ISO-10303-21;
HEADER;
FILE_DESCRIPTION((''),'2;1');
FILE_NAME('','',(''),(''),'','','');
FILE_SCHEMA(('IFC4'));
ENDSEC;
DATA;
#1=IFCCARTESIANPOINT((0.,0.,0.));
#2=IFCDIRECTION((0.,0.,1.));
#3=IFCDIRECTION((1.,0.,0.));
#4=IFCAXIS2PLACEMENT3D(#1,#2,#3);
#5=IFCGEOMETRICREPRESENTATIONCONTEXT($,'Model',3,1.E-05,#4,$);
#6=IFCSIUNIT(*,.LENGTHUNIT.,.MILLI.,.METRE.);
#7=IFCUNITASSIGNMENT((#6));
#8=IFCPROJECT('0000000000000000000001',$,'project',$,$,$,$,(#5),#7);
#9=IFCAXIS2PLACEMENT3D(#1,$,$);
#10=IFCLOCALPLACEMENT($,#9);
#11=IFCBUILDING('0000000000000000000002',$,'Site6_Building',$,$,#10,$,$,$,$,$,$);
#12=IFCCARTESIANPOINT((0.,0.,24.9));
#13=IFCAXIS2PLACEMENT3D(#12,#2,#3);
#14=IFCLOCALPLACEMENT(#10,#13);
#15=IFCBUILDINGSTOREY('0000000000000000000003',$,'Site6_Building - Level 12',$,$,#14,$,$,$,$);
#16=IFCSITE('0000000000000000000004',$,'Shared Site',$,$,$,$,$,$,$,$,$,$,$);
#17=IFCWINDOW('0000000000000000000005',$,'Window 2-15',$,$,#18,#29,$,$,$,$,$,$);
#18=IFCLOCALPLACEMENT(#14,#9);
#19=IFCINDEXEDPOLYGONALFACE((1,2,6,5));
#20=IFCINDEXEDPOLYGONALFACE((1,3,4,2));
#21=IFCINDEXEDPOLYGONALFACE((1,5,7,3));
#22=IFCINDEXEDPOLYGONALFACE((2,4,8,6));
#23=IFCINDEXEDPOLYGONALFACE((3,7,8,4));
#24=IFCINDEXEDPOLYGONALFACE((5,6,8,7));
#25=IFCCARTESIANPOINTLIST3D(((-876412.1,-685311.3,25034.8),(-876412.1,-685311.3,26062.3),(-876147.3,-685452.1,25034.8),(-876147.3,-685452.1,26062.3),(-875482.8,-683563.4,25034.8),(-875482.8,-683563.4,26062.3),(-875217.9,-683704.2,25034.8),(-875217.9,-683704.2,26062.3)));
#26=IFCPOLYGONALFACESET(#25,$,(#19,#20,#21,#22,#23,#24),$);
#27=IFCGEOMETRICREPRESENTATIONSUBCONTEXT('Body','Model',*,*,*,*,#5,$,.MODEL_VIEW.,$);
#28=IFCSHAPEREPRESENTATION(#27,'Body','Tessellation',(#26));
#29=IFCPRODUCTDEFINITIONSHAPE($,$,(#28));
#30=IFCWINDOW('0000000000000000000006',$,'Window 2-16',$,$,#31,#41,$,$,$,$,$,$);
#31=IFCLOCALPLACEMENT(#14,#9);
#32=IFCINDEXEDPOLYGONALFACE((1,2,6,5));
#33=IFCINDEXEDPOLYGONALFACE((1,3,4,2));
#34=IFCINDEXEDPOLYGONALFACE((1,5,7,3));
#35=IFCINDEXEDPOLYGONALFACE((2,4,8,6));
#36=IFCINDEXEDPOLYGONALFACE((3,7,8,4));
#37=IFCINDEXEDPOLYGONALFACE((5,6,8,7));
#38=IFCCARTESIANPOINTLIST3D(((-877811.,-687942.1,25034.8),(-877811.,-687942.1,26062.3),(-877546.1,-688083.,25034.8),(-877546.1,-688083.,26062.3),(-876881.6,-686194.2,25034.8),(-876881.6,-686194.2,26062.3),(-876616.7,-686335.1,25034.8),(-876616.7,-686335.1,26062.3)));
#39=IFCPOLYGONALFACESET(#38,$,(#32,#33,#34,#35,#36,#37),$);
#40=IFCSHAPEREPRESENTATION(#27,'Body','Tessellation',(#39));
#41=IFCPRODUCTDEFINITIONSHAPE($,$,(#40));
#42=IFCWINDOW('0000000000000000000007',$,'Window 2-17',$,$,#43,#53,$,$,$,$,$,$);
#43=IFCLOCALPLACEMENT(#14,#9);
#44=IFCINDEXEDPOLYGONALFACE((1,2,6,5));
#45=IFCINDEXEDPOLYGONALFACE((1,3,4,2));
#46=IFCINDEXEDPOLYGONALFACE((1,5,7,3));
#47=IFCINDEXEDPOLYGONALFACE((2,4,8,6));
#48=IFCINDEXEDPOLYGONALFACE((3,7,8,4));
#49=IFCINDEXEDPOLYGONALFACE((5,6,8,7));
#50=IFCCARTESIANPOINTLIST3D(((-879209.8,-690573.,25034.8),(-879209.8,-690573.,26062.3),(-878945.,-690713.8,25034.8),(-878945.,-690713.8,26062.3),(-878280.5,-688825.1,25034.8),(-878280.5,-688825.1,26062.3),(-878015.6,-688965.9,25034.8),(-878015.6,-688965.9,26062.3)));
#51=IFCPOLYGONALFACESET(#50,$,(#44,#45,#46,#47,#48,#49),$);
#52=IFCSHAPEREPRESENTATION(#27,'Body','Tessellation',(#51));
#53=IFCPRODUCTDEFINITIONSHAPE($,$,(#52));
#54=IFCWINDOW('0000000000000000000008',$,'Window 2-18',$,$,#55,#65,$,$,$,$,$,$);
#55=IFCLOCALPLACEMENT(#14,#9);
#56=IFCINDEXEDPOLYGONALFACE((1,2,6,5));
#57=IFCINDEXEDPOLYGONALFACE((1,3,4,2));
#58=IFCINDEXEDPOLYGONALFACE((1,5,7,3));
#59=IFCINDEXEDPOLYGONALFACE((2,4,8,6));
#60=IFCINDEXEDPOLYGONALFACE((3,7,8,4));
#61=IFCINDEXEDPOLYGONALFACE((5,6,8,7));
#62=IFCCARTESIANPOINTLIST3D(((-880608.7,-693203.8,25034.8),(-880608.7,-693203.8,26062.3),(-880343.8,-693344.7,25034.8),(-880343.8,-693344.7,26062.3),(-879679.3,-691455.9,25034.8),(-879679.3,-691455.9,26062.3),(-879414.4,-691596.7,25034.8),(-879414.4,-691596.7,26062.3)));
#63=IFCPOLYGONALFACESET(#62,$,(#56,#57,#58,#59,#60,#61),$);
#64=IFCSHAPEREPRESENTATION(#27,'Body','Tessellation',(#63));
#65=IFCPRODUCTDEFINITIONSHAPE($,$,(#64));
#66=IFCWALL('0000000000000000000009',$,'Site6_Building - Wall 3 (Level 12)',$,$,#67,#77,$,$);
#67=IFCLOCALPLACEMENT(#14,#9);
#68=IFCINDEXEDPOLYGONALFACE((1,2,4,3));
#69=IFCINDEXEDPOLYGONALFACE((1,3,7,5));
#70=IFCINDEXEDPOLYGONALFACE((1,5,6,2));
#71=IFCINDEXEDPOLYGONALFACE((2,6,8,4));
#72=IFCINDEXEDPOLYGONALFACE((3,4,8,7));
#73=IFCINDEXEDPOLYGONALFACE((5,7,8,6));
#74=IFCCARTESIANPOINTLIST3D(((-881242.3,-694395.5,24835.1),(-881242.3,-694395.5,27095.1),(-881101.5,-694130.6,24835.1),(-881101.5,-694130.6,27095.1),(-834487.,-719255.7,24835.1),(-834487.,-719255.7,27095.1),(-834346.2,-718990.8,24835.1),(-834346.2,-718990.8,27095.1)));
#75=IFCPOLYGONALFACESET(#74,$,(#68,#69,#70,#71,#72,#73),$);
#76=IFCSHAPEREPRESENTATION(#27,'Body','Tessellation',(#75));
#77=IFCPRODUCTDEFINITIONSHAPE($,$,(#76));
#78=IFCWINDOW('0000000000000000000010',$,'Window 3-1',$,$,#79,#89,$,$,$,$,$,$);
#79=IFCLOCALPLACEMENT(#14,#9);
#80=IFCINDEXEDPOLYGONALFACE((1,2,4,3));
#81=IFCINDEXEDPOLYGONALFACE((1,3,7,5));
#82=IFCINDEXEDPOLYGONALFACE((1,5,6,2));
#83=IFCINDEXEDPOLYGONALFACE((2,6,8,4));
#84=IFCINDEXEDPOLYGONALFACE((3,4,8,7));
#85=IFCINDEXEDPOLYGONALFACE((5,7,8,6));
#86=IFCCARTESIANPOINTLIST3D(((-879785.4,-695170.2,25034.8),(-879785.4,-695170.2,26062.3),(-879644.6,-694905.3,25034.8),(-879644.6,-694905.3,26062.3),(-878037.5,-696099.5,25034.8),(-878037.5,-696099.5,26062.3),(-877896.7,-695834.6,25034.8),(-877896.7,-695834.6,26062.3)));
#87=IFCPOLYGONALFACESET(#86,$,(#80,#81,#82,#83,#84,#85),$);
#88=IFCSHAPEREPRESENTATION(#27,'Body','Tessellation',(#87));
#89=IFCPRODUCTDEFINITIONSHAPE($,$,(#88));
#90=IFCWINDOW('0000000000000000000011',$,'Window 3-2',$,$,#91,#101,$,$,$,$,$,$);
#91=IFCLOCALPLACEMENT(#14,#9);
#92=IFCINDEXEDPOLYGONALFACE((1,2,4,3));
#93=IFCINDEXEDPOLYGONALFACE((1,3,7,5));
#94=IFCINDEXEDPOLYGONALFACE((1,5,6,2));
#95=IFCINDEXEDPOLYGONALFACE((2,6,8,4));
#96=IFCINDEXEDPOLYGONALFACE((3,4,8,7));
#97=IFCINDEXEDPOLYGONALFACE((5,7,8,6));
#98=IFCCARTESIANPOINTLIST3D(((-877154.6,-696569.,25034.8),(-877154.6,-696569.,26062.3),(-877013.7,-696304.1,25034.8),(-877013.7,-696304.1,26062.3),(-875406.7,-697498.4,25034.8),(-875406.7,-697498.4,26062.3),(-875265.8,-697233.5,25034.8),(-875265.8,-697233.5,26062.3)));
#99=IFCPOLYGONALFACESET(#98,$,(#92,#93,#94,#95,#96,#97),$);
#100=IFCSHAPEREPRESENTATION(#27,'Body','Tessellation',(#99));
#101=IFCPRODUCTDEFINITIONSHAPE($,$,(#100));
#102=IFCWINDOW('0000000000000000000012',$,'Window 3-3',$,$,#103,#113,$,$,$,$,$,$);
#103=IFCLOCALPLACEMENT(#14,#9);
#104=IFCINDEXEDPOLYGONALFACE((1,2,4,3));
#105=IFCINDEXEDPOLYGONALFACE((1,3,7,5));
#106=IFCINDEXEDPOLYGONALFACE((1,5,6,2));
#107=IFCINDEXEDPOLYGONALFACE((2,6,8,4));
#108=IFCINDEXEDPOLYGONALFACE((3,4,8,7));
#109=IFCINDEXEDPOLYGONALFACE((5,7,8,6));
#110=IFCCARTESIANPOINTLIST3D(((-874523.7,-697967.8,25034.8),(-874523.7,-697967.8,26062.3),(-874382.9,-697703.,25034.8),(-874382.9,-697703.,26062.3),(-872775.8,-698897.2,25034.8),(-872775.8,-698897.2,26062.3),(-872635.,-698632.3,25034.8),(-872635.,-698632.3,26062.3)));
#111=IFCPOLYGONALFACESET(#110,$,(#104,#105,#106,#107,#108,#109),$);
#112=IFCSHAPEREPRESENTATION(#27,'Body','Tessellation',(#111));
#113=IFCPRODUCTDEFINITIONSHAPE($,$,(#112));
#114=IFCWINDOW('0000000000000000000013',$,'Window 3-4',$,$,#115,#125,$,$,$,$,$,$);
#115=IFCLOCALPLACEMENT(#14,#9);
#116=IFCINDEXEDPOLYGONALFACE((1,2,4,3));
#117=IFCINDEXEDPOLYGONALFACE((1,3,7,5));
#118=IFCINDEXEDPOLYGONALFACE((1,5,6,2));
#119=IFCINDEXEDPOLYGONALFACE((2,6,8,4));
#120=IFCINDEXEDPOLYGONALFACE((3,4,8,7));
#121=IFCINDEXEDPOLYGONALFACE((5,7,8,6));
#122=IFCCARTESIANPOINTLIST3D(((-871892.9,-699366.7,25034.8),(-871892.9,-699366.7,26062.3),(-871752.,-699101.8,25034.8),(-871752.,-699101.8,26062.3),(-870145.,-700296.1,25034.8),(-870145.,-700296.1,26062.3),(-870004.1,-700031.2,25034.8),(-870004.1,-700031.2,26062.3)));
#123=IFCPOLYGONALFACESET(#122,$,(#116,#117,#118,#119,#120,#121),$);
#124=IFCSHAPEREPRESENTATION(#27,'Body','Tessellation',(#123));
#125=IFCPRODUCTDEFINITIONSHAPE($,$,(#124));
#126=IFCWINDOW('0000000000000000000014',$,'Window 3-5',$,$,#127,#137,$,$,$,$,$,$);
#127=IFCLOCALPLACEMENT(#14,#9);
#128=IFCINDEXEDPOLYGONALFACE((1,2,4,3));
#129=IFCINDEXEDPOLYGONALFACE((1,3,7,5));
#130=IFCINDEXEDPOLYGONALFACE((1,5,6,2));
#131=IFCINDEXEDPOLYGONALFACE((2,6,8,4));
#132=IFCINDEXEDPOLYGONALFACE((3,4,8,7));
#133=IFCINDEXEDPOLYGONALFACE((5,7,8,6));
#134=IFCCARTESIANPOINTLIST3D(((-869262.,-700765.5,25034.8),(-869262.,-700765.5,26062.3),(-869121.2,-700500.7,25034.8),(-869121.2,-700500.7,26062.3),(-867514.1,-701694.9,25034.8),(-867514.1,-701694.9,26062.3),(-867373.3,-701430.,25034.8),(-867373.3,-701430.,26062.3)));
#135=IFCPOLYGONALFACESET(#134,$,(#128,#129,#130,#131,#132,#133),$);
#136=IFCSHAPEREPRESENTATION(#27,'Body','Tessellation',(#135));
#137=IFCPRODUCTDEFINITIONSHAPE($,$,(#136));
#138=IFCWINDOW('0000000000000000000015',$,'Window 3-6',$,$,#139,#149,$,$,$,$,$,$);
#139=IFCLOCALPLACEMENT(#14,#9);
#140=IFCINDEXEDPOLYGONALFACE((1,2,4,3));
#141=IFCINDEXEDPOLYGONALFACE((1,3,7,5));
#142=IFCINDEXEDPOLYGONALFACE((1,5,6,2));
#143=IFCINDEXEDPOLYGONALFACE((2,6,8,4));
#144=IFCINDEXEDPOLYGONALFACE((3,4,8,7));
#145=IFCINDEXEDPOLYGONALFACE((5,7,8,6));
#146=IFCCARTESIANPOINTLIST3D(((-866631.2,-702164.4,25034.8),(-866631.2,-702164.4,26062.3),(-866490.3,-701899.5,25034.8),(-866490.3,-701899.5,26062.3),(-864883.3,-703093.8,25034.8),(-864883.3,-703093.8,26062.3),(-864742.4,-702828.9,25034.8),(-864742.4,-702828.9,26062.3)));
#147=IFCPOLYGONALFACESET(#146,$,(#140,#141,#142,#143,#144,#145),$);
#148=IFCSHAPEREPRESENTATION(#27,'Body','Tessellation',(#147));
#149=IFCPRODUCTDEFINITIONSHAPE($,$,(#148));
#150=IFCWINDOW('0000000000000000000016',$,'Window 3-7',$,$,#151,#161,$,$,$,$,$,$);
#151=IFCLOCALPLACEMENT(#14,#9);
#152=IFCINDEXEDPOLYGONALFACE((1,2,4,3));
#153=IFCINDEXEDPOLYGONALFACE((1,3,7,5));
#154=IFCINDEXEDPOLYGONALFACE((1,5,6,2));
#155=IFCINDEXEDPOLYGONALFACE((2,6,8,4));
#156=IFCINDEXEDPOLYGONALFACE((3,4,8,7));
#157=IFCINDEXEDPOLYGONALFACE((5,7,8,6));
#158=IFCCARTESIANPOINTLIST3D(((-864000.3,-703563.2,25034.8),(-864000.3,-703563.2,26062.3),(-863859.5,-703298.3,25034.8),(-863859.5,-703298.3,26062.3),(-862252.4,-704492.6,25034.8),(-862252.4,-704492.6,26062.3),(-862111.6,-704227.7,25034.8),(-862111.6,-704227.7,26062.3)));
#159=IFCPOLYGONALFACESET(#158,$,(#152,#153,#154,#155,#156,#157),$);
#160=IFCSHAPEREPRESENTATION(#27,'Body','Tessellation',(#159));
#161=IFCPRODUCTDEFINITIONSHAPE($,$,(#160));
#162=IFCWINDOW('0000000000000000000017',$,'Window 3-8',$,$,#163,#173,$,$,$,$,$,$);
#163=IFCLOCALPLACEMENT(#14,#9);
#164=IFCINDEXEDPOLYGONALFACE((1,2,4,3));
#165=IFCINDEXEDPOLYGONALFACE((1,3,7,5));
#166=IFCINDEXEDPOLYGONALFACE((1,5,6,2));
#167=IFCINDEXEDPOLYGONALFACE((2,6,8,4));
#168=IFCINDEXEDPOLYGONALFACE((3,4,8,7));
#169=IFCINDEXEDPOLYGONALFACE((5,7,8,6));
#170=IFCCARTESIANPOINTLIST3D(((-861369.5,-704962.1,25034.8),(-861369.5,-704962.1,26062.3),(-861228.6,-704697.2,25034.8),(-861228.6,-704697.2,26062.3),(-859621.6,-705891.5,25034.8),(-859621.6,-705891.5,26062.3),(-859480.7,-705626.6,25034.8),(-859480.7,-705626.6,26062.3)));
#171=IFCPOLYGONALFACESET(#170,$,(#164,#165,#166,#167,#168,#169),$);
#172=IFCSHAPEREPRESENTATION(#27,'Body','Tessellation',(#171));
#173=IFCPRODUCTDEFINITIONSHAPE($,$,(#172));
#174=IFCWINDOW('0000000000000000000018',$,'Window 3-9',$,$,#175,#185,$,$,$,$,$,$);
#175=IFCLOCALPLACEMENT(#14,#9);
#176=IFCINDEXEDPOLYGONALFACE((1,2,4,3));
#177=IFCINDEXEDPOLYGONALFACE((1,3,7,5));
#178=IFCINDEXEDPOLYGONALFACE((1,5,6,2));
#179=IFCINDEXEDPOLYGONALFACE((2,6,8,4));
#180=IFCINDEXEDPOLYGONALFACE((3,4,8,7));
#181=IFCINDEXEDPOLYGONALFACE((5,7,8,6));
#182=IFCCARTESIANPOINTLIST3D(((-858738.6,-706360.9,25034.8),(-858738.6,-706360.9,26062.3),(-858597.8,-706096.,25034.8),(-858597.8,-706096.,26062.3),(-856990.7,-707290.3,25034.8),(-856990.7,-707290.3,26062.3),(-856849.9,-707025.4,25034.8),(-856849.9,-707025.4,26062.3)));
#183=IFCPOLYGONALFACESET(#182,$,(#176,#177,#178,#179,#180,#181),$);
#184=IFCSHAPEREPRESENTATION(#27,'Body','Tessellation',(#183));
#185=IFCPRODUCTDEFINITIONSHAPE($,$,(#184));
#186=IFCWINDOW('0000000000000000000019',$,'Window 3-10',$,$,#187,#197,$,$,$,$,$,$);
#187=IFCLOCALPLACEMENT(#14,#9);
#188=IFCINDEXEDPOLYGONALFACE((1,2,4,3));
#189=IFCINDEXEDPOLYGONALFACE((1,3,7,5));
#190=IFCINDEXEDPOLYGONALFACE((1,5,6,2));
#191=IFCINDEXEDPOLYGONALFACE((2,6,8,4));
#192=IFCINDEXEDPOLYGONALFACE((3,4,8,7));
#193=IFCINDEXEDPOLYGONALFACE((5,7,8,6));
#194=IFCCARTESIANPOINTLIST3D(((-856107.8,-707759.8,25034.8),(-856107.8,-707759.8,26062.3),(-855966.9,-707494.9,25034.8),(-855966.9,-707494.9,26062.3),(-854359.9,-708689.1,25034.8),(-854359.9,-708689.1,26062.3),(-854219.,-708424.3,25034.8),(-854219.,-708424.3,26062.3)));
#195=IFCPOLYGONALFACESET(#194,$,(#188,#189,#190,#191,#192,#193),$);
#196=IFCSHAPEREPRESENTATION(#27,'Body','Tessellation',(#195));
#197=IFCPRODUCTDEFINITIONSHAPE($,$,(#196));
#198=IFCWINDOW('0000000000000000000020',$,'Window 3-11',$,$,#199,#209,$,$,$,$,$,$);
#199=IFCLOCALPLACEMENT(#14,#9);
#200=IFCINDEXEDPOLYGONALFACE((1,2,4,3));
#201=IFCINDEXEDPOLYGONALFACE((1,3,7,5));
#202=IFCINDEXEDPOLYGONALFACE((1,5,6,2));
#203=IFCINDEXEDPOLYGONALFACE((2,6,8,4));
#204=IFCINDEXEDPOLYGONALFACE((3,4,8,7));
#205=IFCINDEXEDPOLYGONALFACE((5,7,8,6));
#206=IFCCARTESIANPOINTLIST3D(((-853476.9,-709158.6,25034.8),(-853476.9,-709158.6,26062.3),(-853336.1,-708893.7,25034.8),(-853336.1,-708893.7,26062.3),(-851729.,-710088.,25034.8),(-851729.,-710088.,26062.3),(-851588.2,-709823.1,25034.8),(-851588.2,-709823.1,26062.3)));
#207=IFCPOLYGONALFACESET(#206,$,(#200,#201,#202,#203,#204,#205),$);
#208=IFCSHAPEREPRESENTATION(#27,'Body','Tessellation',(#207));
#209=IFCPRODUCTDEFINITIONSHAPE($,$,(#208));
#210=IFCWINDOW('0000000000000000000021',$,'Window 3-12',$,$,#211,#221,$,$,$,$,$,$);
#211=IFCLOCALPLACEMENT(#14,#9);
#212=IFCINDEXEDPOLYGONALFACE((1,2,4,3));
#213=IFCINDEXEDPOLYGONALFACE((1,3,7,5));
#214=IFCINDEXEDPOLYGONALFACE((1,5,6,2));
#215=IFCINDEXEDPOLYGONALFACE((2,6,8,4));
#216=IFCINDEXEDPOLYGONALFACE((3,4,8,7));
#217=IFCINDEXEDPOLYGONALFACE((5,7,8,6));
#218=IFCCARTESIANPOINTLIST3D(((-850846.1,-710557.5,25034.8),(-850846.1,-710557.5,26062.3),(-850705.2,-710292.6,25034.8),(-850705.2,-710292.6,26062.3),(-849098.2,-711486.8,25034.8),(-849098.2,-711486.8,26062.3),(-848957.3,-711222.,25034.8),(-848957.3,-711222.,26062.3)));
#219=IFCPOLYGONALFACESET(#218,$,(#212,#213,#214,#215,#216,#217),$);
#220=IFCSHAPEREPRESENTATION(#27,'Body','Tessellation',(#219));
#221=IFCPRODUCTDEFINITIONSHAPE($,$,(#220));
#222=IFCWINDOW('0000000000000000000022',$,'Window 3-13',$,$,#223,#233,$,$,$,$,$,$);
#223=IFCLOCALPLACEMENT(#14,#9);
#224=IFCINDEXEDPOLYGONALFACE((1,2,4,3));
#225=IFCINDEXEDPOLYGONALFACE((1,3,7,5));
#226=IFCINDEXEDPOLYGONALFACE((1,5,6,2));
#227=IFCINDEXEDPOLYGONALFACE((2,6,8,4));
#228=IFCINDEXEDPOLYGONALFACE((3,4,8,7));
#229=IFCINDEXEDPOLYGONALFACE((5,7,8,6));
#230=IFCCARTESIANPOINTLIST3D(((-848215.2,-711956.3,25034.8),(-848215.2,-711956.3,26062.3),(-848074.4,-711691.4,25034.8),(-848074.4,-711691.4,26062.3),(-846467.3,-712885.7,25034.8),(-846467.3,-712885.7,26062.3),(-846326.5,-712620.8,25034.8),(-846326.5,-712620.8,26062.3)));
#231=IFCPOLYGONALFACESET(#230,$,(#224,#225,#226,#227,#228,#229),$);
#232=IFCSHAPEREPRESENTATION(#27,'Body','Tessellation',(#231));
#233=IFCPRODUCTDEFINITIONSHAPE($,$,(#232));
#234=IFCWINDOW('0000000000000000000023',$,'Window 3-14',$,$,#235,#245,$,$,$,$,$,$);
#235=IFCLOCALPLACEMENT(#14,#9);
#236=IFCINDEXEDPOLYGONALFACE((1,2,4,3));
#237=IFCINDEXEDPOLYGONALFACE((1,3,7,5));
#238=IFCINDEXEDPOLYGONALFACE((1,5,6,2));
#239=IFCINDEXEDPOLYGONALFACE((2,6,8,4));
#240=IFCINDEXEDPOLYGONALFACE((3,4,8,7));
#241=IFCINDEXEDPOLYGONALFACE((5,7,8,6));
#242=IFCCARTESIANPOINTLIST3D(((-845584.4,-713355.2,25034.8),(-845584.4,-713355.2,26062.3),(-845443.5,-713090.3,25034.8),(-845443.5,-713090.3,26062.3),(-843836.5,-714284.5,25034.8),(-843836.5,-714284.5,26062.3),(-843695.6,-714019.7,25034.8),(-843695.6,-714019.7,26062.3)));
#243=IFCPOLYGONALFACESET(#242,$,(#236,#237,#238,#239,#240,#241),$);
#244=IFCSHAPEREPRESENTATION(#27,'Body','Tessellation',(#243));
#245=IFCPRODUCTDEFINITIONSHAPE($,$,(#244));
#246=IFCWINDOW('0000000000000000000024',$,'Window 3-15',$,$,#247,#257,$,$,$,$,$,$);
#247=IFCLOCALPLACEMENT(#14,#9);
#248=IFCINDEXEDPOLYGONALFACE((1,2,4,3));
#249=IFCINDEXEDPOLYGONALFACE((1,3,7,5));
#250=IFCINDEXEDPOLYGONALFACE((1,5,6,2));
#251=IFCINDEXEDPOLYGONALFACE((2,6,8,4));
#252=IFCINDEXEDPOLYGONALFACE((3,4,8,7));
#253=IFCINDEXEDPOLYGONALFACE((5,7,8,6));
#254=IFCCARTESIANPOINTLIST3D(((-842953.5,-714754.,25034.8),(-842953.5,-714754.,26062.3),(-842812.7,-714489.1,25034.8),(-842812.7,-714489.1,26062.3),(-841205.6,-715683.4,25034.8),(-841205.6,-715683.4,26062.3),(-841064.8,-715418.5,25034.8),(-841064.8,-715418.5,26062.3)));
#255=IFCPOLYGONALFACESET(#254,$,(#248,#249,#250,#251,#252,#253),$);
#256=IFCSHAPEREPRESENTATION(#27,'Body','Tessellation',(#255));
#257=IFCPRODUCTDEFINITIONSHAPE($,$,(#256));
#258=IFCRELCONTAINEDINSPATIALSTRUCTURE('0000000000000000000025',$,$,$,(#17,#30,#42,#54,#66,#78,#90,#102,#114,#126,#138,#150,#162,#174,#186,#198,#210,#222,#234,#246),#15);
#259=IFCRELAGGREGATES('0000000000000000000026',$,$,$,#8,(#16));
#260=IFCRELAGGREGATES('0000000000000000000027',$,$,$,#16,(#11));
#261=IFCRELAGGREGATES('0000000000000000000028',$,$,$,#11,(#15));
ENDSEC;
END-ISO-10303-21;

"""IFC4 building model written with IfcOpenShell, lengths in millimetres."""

from ifc_helpers import new_model, si_unit, frame, origin, origin_with_axes, place, context, subcontext, project, spatial, indexed_curve, outline, extrude, element, save


model = new_model("IFC4")

# Units and contexts
model_context = context("Model", 3, precision=1e-05, world=origin_with_axes())
body_context = subcontext(model_context, "Body", "Model", "MODEL_VIEW")
ifc_project = project(units=[si_unit("LENGTHUNIT", "METRE", prefix="MILLI")], contexts=[model_context])

# Site, building, storey
site = spatial("IfcSite", under=ifc_project, Name="Shared Site")
building_placement = place(None, origin())
building = spatial("IfcBuilding", under=site, at=building_placement, Name="Site6_Building")
storey_placement = place(building_placement, frame((0.0, 0.0, 24.9), z_axis=(0.0, 0.0, 1.0), x_axis=(1.0, 0.0, 0.0)))
storey = spatial("IfcBuildingStorey", under=building, at=storey_placement, Name="Site6_Building - Level 12")

# Windows
for number, where, z_axis, x_axis, name in (
    (1, (-875482.8, -683563.4, 25034.8), (0.0, 0.0, 1.0), (-0.469472, -0.882948, 0.0), "Window 2-15"),
    (2, (-876881.6, -686194.2, 25034.8), (0.0, 0.0, 1.0), (-0.469472, -0.882948, 0.0), "Window 2-16"),
    (3, (-878280.5, -688825.1, 25034.8), (0.0, 0.0, 1.0), (-0.469472, -0.882948, 0.0), "Window 2-17"),
    (4, (-879679.3, -691455.9, 25034.8), (0.0, 0.0, 1.0), (-0.469472, -0.882948, 0.0), "Window 2-18"),
):
    element("IfcWindow", number, at=place(storey_placement, frame(where, z_axis=z_axis, x_axis=x_axis)), inside=storey, Name=name, context=body_context, shape_type="SweptSolid", body=[
        extrude(outline(indexed_curve([(0.0, 0.0), (0.0, 300.0), (1979.6, 300.0), (1979.6, 0.0), (0.0, 0.0)], self_intersect=False)), origin_with_axes(), (0.0, 0.0, 1.0), 1027.5),
    ])

# Wall
wall_1_placement = place(storey_placement, frame((-881242.3, -694395.5, 24835.1), z_axis=(0.0, 0.0, 1.0), x_axis=(0.882948, -0.469472, 0.0)))
element("IfcWall", 5, at=wall_1_placement, inside=storey, Name="Site6_Building - Wall 3 (Level 12)", context=body_context, shape_type="SweptSolid", body=[
    extrude(outline(indexed_curve([(0.0, 0.0), (0.0, 300.0), (52953.6, 300.0), (52953.6, 0.0), (0.0, 0.0)], self_intersect=False)), origin_with_axes(), (0.0, 0.0, 1.0), 2260.0),
])

# Windows
for number, where, z_axis, x_axis, name in (
    (6, (-879785.4, -695170.2, 25034.8), (0.0, 0.0, 1.0), (0.882948, -0.469472, 0.0), "Window 3-1"),
    (7, (-877154.6, -696569.0, 25034.8), (0.0, 0.0, 1.0), (0.882948, -0.469472, 0.0), "Window 3-2"),
    (8, (-874523.7, -697967.8, 25034.8), (0.0, 0.0, 1.0), (0.882948, -0.469472, 0.0), "Window 3-3"),
    (9, (-871892.9, -699366.7, 25034.8), (0.0, 0.0, 1.0), (0.882948, -0.469472, 0.0), "Window 3-4"),
    (10, (-869262.0, -700765.5, 25034.8), (0.0, 0.0, 1.0), (0.882948, -0.469472, 0.0), "Window 3-5"),
    (11, (-866631.2, -702164.4, 25034.8), (0.0, 0.0, 1.0), (0.882948, -0.469472, 0.0), "Window 3-6"),
    (12, (-864000.3, -703563.2, 25034.8), (0.0, 0.0, 1.0), (0.882948, -0.469472, 0.0), "Window 3-7"),
    (13, (-861369.5, -704962.1, 25034.8), (0.0, 0.0, 1.0), (0.882948, -0.469472, 0.0), "Window 3-8"),
    (14, (-858738.6, -706360.9, 25034.8), (0.0, 0.0, 1.0), (0.882948, -0.469472, 0.0), "Window 3-9"),
    (15, (-856107.8, -707759.8, 25034.8), (0.0, 0.0, 1.0), (0.882948, -0.469472, 0.0), "Window 3-10"),
    (16, (-853476.9, -709158.6, 25034.8), (0.0, 0.0, 1.0), (0.882948, -0.469472, 0.0), "Window 3-11"),
    (17, (-850846.1, -710557.5, 25034.8), (0.0, 0.0, 1.0), (0.882948, -0.469472, 0.0), "Window 3-12"),
    (18, (-848215.2, -711956.3, 25034.8), (0.0, 0.0, 1.0), (0.882948, -0.469472, 0.0), "Window 3-13"),
    (19, (-845584.4, -713355.2, 25034.8), (0.0, 0.0, 1.0), (0.882948, -0.469472, 0.0), "Window 3-14"),
    (20, (-842953.5, -714754.0, 25034.8), (0.0, 0.0, 1.0), (0.882948, -0.469472, 0.0), "Window 3-15"),
):
    element("IfcWindow", number, at=place(storey_placement, frame(where, z_axis=z_axis, x_axis=x_axis)), inside=storey, Name=name, context=body_context, shape_type="SweptSolid", body=[
        extrude(outline(indexed_curve([(0.0, 0.0), (0.0, 300.0), (1979.6, 300.0), (1979.6, 0.0), (0.0, 0.0)], self_intersect=False)), origin_with_axes(), (0.0, 0.0, 1.0), 1027.5),
    ])

save(model, "model.ifc")
